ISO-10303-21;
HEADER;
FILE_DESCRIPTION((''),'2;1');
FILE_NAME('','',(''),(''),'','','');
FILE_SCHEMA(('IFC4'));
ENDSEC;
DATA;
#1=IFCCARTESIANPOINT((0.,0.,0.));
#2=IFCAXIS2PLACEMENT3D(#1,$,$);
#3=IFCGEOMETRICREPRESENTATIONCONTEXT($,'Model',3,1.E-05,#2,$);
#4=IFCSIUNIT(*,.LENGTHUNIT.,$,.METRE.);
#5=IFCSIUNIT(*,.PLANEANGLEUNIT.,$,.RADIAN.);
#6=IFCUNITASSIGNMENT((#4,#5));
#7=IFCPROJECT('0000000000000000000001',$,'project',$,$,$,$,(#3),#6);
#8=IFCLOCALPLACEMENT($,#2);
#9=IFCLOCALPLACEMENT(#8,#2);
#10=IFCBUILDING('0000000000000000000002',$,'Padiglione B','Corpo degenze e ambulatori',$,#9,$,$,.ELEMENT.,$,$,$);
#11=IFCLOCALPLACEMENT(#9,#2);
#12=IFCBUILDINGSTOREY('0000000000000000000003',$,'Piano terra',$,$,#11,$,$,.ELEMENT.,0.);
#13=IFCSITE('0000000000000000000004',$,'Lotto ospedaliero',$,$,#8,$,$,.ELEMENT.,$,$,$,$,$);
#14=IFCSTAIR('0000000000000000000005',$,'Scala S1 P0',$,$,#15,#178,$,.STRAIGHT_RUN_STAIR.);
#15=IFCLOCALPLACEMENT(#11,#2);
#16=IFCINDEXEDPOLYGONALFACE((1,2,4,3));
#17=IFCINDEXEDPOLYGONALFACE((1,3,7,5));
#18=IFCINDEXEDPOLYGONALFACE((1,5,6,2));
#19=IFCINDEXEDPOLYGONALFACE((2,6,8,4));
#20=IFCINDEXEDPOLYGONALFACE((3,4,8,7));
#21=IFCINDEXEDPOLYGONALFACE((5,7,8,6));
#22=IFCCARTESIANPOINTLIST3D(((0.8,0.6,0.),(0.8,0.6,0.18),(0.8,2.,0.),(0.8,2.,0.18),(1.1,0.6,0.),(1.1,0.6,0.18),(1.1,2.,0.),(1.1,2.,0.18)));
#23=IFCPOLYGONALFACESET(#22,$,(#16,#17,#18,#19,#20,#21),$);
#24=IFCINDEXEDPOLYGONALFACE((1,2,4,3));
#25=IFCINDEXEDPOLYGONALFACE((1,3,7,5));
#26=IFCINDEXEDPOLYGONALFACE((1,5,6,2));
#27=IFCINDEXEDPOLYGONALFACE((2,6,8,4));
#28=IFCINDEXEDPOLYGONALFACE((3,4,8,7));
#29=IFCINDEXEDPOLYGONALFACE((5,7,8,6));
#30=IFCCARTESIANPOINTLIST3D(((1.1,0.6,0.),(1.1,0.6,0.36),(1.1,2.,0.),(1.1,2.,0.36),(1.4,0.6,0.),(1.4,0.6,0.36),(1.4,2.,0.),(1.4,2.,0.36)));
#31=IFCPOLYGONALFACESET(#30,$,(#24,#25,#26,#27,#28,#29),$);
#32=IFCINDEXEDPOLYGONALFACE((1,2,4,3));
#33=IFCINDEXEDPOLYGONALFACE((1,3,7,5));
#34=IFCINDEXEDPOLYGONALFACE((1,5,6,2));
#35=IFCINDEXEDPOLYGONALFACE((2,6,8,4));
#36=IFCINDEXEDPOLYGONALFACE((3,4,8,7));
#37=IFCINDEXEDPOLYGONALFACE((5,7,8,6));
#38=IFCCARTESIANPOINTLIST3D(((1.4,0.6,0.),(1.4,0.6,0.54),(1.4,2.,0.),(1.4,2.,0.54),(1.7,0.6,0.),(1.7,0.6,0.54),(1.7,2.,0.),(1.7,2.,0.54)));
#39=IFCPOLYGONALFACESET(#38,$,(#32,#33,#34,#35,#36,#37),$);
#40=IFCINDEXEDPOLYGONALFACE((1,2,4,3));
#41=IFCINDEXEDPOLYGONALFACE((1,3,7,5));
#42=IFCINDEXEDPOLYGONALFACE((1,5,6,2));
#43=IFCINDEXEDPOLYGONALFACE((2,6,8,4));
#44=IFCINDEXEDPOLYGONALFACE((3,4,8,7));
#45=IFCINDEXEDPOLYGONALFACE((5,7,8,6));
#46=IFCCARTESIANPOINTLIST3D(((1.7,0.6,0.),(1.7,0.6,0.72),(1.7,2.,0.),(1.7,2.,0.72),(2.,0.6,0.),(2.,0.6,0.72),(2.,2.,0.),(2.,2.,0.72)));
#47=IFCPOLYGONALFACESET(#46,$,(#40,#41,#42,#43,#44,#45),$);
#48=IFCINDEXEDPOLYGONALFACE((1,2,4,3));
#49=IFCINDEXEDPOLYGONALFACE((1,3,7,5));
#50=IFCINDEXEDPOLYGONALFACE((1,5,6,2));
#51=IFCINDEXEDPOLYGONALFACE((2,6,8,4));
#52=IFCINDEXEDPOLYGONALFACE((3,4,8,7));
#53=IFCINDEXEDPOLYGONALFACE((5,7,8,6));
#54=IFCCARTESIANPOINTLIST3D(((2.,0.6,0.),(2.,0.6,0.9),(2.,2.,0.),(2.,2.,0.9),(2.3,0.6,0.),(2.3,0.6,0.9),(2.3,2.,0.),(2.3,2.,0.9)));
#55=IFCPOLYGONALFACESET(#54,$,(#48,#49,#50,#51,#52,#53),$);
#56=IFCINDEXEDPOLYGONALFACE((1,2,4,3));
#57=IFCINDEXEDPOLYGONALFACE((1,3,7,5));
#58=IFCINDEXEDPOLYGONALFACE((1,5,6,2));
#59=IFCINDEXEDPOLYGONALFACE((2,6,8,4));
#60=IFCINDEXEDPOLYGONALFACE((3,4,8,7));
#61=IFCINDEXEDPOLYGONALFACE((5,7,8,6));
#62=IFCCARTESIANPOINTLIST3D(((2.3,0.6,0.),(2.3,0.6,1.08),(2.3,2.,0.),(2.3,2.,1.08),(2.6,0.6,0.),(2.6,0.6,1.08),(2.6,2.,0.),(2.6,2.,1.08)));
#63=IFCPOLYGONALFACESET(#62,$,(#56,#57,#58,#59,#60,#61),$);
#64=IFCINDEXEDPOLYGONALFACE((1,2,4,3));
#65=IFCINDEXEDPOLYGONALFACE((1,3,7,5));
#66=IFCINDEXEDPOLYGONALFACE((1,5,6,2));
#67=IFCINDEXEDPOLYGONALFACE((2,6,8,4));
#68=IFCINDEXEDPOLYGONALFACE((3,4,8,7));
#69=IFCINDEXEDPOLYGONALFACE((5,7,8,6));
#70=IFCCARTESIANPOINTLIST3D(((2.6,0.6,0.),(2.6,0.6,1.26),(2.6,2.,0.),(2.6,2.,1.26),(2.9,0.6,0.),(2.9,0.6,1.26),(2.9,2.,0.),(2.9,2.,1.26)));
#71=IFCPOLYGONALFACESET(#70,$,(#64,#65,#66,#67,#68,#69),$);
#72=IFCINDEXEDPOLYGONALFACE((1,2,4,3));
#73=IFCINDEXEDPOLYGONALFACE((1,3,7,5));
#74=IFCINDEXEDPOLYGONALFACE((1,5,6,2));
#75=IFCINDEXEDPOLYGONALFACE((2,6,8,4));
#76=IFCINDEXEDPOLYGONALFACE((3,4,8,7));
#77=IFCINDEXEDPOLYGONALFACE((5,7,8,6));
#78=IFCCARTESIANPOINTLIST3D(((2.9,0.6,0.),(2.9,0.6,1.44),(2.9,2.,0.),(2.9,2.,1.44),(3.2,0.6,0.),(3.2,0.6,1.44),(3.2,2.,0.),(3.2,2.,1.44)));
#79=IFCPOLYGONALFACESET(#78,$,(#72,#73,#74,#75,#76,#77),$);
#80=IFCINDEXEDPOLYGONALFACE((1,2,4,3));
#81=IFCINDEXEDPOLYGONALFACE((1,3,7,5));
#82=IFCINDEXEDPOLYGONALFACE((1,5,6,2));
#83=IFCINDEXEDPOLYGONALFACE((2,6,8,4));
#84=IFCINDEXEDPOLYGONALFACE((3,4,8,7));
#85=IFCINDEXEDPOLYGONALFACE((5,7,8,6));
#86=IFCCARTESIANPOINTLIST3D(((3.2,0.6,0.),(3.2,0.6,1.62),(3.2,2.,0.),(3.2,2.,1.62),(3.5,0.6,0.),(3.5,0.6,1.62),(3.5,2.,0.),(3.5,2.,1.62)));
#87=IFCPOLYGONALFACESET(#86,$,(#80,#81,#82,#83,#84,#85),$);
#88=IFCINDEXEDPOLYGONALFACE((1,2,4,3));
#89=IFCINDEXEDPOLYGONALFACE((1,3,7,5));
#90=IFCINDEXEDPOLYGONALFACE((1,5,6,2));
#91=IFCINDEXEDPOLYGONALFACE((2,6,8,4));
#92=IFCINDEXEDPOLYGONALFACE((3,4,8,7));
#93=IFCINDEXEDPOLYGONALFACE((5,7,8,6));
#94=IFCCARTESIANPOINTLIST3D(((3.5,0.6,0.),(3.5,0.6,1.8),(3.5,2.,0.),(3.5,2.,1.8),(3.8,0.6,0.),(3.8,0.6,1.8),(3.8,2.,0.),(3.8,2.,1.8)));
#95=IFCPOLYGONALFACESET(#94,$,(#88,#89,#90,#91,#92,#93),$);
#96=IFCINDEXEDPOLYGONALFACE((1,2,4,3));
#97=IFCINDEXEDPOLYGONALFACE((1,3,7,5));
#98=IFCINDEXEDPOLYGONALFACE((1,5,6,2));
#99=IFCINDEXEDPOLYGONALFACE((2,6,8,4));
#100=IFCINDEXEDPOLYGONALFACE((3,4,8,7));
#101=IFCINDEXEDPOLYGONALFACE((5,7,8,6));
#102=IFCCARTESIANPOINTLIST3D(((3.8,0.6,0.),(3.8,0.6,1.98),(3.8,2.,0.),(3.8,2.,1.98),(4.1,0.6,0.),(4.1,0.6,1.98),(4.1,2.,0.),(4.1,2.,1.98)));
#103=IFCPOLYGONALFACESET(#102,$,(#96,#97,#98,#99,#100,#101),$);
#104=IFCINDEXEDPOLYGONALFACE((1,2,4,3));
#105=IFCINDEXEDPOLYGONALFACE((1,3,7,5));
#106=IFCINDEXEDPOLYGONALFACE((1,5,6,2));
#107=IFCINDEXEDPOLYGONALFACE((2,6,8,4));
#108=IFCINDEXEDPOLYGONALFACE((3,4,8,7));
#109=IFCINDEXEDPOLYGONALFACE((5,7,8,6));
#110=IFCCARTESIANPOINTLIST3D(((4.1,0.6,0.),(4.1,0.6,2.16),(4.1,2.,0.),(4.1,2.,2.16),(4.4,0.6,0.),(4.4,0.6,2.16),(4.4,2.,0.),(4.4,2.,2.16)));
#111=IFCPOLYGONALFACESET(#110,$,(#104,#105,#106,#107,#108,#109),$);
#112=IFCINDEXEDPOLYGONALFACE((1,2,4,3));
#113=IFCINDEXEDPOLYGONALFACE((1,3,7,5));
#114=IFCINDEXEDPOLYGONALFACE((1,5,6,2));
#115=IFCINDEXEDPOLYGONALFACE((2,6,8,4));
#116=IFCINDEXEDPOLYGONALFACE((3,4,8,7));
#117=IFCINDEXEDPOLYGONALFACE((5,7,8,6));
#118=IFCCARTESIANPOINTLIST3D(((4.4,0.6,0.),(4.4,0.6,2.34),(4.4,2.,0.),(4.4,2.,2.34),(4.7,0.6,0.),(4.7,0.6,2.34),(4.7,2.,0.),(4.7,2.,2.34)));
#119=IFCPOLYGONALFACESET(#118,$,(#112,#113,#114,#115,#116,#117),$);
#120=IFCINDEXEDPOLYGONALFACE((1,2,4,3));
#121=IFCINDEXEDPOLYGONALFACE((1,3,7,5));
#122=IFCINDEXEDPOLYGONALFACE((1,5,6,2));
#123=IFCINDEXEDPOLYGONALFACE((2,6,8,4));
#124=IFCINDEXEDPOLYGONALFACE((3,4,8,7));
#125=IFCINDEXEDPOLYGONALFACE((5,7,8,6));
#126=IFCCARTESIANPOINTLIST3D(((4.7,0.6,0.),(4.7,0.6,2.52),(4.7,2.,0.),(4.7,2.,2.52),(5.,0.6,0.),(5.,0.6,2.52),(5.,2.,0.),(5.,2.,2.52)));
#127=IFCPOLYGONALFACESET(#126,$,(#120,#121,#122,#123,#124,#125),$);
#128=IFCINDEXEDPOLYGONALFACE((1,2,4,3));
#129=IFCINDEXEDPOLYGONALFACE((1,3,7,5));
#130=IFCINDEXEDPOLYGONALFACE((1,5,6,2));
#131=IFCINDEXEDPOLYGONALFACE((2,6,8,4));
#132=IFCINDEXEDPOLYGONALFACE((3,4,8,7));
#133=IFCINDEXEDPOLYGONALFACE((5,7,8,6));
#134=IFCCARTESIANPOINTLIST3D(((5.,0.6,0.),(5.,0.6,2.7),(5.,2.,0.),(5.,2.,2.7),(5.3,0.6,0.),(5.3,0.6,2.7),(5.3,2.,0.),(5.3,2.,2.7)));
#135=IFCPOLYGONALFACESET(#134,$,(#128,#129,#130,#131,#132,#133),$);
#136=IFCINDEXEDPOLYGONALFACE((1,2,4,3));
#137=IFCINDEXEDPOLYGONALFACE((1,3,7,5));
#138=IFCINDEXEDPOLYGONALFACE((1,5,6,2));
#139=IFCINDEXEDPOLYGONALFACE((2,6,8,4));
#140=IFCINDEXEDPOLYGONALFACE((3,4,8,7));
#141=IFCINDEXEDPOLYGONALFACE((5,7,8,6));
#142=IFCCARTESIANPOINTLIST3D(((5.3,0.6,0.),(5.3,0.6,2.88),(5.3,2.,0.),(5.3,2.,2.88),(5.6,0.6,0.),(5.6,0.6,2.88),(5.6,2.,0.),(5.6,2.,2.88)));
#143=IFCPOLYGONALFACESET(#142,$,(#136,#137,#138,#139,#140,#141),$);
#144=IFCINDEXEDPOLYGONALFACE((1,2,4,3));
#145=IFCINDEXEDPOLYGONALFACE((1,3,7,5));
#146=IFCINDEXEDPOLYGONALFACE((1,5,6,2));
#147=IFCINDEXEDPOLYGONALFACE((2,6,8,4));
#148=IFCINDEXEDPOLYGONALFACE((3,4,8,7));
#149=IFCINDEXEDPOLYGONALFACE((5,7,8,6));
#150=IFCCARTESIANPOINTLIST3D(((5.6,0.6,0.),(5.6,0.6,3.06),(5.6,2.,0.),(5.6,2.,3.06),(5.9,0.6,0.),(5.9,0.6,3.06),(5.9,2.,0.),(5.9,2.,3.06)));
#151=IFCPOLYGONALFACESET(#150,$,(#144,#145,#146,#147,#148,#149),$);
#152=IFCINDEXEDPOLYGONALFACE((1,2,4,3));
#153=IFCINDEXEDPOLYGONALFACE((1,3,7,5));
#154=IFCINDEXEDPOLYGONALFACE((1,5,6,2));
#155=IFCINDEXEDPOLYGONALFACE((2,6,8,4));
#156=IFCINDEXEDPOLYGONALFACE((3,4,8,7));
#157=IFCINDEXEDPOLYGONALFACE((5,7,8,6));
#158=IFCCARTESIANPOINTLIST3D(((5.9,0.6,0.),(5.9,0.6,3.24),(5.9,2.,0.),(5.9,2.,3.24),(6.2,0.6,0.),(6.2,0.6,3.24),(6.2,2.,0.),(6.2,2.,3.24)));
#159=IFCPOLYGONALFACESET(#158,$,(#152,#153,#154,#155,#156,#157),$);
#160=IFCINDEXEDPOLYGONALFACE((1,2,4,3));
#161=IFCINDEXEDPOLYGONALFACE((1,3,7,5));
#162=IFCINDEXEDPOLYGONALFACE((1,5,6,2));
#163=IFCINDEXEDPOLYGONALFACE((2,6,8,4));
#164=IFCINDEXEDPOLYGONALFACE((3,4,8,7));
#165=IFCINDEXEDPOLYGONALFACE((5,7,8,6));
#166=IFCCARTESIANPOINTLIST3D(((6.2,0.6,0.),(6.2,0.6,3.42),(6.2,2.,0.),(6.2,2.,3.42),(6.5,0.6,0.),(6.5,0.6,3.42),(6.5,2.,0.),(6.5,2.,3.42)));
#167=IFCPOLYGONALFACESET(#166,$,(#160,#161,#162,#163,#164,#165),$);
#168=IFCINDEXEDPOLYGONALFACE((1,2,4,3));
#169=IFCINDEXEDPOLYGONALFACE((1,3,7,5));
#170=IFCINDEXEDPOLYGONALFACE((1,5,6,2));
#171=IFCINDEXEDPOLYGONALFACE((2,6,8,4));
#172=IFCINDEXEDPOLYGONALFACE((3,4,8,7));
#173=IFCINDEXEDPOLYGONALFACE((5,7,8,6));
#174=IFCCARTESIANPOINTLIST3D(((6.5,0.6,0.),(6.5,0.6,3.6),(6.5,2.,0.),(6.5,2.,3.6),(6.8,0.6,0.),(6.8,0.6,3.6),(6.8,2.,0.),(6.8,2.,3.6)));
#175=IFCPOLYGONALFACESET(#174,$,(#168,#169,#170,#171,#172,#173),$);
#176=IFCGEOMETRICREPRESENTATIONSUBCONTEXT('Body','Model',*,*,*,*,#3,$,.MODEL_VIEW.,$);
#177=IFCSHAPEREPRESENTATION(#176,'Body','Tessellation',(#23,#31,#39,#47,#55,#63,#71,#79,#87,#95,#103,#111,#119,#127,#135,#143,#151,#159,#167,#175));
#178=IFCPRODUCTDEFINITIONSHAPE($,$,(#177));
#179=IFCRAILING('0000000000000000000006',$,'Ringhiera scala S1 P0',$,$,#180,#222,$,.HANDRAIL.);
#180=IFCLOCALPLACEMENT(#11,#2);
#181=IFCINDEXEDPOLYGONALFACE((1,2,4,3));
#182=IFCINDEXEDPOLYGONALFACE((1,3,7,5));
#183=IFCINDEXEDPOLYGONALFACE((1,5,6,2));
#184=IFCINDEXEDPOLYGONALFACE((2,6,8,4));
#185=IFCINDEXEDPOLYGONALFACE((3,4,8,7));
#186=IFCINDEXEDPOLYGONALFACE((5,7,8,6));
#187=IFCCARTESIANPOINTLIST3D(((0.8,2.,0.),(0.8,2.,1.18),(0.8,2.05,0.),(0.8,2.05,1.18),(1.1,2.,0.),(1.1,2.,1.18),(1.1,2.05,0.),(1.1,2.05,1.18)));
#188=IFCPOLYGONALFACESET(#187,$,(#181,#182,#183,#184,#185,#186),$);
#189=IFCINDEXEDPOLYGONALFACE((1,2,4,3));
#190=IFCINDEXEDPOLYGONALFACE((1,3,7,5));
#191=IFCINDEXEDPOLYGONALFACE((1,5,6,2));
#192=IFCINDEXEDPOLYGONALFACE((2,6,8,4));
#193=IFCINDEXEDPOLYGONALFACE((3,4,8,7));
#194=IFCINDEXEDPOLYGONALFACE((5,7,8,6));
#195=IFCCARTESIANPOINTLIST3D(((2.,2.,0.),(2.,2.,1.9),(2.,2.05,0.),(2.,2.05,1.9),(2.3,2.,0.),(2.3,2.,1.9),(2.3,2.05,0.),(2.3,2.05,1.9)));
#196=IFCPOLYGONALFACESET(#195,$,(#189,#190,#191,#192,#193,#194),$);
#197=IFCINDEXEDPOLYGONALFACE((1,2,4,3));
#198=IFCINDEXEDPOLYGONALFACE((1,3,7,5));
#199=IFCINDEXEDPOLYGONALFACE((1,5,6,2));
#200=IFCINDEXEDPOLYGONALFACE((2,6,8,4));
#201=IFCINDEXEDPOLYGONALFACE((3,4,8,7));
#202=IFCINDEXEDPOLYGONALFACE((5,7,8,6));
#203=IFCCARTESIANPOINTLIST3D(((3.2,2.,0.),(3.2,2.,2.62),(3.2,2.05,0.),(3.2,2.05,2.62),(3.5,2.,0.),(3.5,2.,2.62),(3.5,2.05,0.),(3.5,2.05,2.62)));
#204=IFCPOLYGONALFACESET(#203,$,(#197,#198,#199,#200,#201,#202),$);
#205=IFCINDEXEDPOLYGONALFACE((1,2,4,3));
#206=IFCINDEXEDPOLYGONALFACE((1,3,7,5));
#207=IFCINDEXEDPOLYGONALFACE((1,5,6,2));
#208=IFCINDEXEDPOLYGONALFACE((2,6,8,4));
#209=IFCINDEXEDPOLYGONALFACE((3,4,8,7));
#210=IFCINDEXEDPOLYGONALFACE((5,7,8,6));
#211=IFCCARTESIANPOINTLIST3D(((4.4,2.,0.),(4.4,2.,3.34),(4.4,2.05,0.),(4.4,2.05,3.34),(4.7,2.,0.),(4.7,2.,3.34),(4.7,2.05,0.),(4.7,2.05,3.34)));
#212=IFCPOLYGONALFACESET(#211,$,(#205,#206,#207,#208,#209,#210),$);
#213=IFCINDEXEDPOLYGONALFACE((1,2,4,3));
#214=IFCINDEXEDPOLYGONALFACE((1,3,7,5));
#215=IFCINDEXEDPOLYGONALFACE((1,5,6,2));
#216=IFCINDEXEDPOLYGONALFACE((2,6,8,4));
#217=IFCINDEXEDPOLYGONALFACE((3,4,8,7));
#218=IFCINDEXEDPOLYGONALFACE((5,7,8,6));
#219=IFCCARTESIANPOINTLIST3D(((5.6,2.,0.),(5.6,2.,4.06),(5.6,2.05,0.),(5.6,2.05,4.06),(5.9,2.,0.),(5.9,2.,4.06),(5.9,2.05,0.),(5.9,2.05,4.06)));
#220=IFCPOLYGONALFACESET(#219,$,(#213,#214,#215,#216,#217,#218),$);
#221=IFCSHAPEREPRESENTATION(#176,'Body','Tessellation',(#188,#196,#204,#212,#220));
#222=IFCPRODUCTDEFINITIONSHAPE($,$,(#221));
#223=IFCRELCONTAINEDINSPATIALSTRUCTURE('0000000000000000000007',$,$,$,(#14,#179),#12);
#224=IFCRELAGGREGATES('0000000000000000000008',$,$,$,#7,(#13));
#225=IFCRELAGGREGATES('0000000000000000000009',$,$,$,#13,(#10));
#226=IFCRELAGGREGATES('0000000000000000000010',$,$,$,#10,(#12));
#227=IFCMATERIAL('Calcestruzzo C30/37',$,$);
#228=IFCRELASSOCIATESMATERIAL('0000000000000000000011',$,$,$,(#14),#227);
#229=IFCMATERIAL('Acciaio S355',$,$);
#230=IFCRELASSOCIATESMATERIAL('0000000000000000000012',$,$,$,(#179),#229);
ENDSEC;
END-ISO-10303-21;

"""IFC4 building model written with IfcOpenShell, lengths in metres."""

from ifc_helpers import new_model, si_unit, frame, frame_2d, origin, place, context, subcontext, project, spatial, rectangle, extrude, material, element, save


model = new_model("IFC4")

# Units and contexts
model_context = context("Model", 3, precision=1e-05, world=origin())
body_context = subcontext(model_context, "Body", "Model", "MODEL_VIEW")
ifc_project = project(units=[si_unit("LENGTHUNIT", "METRE"), si_unit("PLANEANGLEUNIT", "RADIAN")], contexts=[model_context])

# Site, building, storey
site_placement = place(None, origin())
site = spatial("IfcSite", under=ifc_project, at=site_placement, Name="Lotto ospedaliero", CompositionType="ELEMENT")
building_placement = place(site_placement, origin())
building = spatial("IfcBuilding", under=site, at=building_placement, Name="Padiglione B", Description="Corpo degenze e ambulatori", CompositionType="ELEMENT")
storey_placement = place(building_placement, origin())
storey = spatial("IfcBuildingStorey", under=building, at=storey_placement, Name="Piano terra", CompositionType="ELEMENT", Elevation=0.0)

# Shared definitions
ifc_material_1 = material(Name="Calcestruzzo C30/37")

# Stair
stair_placement = place(storey_placement, frame((0.8, 0.6, 0.0)))
element("IfcStair", 1, at=stair_placement, inside=storey, material=ifc_material_1, Name="Scala S1 P0", PredefinedType="STRAIGHT_RUN_STAIR", context=body_context, shape_type="SweptSolid", body=[
    extrude(rectangle(XDim=0.3, YDim=1.4, at=frame_2d((0.15, 0.7))), origin(), (0.0, 0.0, 1.0), 0.18),
    extrude(rectangle(XDim=0.3, YDim=1.4, at=frame_2d((0.15, 0.7))), frame((0.3, 0.0, 0.0)), (0.0, 0.0, 1.0), 0.36),
    extrude(rectangle(XDim=0.3, YDim=1.4, at=frame_2d((0.15, 0.7))), frame((0.6, 0.0, 0.0)), (0.0, 0.0, 1.0), 0.54),
    extrude(rectangle(XDim=0.3, YDim=1.4, at=frame_2d((0.15, 0.7))), frame((0.9, 0.0, 0.0)), (0.0, 0.0, 1.0), 0.72),
    extrude(rectangle(XDim=0.3, YDim=1.4, at=frame_2d((0.15, 0.7))), frame((1.2, 0.0, 0.0)), (0.0, 0.0, 1.0), 0.9),
    extrude(rectangle(XDim=0.3, YDim=1.4, at=frame_2d((0.15, 0.7))), frame((1.5, 0.0, 0.0)), (0.0, 0.0, 1.0), 1.08),
    extrude(rectangle(XDim=0.3, YDim=1.4, at=frame_2d((0.15, 0.7))), frame((1.8, 0.0, 0.0)), (0.0, 0.0, 1.0), 1.26),
    extrude(rectangle(XDim=0.3, YDim=1.4, at=frame_2d((0.15, 0.7))), frame((2.1, 0.0, 0.0)), (0.0, 0.0, 1.0), 1.44),
    extrude(rectangle(XDim=0.3, YDim=1.4, at=frame_2d((0.15, 0.7))), frame((2.4, 0.0, 0.0)), (0.0, 0.0, 1.0), 1.62),
    extrude(rectangle(XDim=0.3, YDim=1.4, at=frame_2d((0.15, 0.7))), frame((2.7, 0.0, 0.0)), (0.0, 0.0, 1.0), 1.8),
    extrude(rectangle(XDim=0.3, YDim=1.4, at=frame_2d((0.15, 0.7))), frame((3.0, 0.0, 0.0)), (0.0, 0.0, 1.0), 1.98),
    extrude(rectangle(XDim=0.3, YDim=1.4, at=frame_2d((0.15, 0.7))), frame((3.3, 0.0, 0.0)), (0.0, 0.0, 1.0), 2.16),
    extrude(rectangle(XDim=0.3, YDim=1.4, at=frame_2d((0.15, 0.7))), frame((3.6, 0.0, 0.0)), (0.0, 0.0, 1.0), 2.34),
    extrude(rectangle(XDim=0.3, YDim=1.4, at=frame_2d((0.15, 0.7))), frame((3.9, 0.0, 0.0)), (0.0, 0.0, 1.0), 2.52),
    extrude(rectangle(XDim=0.3, YDim=1.4, at=frame_2d((0.15, 0.7))), frame((4.2, 0.0, 0.0)), (0.0, 0.0, 1.0), 2.7),
    extrude(rectangle(XDim=0.3, YDim=1.4, at=frame_2d((0.15, 0.7))), frame((4.5, 0.0, 0.0)), (0.0, 0.0, 1.0), 2.88),
    extrude(rectangle(XDim=0.3, YDim=1.4, at=frame_2d((0.15, 0.7))), frame((4.8, 0.0, 0.0)), (0.0, 0.0, 1.0), 3.06),
    extrude(rectangle(XDim=0.3, YDim=1.4, at=frame_2d((0.15, 0.7))), frame((5.1, 0.0, 0.0)), (0.0, 0.0, 1.0), 3.24),
    extrude(rectangle(XDim=0.3, YDim=1.4, at=frame_2d((0.15, 0.7))), frame((5.4, 0.0, 0.0)), (0.0, 0.0, 1.0), 3.42),
    extrude(rectangle(XDim=0.3, YDim=1.4, at=frame_2d((0.15, 0.7))), frame((5.7, 0.0, 0.0)), (0.0, 0.0, 1.0), 3.6),
])

# Railing
ifc_material_2 = material(Name="Acciaio S355")
railing_placement = place(storey_placement, frame((0.8, 2.0, 0.0)))
element("IfcRailing", 2, at=railing_placement, inside=storey, material=ifc_material_2, Name="Ringhiera scala S1 P0", PredefinedType="HANDRAIL", context=body_context, shape_type="SweptSolid", body=[
    extrude(rectangle(XDim=0.3, YDim=0.05, at=frame_2d((0.15, 0.025))), origin(), (0.0, 0.0, 1.0), 1.18),
    extrude(rectangle(XDim=0.3, YDim=0.05, at=frame_2d((0.15, 0.025))), frame((1.2, 0.0, 0.0)), (0.0, 0.0, 1.0), 1.9),
    extrude(rectangle(XDim=0.3, YDim=0.05, at=frame_2d((0.15, 0.025))), frame((2.4, 0.0, 0.0)), (0.0, 0.0, 1.0), 2.62),
    extrude(rectangle(XDim=0.3, YDim=0.05, at=frame_2d((0.15, 0.025))), frame((3.6, 0.0, 0.0)), (0.0, 0.0, 1.0), 3.34),
    extrude(rectangle(XDim=0.3, YDim=0.05, at=frame_2d((0.15, 0.025))), frame((4.8, 0.0, 0.0)), (0.0, 0.0, 1.0), 4.06),
])

save(model, "model.ifc")
